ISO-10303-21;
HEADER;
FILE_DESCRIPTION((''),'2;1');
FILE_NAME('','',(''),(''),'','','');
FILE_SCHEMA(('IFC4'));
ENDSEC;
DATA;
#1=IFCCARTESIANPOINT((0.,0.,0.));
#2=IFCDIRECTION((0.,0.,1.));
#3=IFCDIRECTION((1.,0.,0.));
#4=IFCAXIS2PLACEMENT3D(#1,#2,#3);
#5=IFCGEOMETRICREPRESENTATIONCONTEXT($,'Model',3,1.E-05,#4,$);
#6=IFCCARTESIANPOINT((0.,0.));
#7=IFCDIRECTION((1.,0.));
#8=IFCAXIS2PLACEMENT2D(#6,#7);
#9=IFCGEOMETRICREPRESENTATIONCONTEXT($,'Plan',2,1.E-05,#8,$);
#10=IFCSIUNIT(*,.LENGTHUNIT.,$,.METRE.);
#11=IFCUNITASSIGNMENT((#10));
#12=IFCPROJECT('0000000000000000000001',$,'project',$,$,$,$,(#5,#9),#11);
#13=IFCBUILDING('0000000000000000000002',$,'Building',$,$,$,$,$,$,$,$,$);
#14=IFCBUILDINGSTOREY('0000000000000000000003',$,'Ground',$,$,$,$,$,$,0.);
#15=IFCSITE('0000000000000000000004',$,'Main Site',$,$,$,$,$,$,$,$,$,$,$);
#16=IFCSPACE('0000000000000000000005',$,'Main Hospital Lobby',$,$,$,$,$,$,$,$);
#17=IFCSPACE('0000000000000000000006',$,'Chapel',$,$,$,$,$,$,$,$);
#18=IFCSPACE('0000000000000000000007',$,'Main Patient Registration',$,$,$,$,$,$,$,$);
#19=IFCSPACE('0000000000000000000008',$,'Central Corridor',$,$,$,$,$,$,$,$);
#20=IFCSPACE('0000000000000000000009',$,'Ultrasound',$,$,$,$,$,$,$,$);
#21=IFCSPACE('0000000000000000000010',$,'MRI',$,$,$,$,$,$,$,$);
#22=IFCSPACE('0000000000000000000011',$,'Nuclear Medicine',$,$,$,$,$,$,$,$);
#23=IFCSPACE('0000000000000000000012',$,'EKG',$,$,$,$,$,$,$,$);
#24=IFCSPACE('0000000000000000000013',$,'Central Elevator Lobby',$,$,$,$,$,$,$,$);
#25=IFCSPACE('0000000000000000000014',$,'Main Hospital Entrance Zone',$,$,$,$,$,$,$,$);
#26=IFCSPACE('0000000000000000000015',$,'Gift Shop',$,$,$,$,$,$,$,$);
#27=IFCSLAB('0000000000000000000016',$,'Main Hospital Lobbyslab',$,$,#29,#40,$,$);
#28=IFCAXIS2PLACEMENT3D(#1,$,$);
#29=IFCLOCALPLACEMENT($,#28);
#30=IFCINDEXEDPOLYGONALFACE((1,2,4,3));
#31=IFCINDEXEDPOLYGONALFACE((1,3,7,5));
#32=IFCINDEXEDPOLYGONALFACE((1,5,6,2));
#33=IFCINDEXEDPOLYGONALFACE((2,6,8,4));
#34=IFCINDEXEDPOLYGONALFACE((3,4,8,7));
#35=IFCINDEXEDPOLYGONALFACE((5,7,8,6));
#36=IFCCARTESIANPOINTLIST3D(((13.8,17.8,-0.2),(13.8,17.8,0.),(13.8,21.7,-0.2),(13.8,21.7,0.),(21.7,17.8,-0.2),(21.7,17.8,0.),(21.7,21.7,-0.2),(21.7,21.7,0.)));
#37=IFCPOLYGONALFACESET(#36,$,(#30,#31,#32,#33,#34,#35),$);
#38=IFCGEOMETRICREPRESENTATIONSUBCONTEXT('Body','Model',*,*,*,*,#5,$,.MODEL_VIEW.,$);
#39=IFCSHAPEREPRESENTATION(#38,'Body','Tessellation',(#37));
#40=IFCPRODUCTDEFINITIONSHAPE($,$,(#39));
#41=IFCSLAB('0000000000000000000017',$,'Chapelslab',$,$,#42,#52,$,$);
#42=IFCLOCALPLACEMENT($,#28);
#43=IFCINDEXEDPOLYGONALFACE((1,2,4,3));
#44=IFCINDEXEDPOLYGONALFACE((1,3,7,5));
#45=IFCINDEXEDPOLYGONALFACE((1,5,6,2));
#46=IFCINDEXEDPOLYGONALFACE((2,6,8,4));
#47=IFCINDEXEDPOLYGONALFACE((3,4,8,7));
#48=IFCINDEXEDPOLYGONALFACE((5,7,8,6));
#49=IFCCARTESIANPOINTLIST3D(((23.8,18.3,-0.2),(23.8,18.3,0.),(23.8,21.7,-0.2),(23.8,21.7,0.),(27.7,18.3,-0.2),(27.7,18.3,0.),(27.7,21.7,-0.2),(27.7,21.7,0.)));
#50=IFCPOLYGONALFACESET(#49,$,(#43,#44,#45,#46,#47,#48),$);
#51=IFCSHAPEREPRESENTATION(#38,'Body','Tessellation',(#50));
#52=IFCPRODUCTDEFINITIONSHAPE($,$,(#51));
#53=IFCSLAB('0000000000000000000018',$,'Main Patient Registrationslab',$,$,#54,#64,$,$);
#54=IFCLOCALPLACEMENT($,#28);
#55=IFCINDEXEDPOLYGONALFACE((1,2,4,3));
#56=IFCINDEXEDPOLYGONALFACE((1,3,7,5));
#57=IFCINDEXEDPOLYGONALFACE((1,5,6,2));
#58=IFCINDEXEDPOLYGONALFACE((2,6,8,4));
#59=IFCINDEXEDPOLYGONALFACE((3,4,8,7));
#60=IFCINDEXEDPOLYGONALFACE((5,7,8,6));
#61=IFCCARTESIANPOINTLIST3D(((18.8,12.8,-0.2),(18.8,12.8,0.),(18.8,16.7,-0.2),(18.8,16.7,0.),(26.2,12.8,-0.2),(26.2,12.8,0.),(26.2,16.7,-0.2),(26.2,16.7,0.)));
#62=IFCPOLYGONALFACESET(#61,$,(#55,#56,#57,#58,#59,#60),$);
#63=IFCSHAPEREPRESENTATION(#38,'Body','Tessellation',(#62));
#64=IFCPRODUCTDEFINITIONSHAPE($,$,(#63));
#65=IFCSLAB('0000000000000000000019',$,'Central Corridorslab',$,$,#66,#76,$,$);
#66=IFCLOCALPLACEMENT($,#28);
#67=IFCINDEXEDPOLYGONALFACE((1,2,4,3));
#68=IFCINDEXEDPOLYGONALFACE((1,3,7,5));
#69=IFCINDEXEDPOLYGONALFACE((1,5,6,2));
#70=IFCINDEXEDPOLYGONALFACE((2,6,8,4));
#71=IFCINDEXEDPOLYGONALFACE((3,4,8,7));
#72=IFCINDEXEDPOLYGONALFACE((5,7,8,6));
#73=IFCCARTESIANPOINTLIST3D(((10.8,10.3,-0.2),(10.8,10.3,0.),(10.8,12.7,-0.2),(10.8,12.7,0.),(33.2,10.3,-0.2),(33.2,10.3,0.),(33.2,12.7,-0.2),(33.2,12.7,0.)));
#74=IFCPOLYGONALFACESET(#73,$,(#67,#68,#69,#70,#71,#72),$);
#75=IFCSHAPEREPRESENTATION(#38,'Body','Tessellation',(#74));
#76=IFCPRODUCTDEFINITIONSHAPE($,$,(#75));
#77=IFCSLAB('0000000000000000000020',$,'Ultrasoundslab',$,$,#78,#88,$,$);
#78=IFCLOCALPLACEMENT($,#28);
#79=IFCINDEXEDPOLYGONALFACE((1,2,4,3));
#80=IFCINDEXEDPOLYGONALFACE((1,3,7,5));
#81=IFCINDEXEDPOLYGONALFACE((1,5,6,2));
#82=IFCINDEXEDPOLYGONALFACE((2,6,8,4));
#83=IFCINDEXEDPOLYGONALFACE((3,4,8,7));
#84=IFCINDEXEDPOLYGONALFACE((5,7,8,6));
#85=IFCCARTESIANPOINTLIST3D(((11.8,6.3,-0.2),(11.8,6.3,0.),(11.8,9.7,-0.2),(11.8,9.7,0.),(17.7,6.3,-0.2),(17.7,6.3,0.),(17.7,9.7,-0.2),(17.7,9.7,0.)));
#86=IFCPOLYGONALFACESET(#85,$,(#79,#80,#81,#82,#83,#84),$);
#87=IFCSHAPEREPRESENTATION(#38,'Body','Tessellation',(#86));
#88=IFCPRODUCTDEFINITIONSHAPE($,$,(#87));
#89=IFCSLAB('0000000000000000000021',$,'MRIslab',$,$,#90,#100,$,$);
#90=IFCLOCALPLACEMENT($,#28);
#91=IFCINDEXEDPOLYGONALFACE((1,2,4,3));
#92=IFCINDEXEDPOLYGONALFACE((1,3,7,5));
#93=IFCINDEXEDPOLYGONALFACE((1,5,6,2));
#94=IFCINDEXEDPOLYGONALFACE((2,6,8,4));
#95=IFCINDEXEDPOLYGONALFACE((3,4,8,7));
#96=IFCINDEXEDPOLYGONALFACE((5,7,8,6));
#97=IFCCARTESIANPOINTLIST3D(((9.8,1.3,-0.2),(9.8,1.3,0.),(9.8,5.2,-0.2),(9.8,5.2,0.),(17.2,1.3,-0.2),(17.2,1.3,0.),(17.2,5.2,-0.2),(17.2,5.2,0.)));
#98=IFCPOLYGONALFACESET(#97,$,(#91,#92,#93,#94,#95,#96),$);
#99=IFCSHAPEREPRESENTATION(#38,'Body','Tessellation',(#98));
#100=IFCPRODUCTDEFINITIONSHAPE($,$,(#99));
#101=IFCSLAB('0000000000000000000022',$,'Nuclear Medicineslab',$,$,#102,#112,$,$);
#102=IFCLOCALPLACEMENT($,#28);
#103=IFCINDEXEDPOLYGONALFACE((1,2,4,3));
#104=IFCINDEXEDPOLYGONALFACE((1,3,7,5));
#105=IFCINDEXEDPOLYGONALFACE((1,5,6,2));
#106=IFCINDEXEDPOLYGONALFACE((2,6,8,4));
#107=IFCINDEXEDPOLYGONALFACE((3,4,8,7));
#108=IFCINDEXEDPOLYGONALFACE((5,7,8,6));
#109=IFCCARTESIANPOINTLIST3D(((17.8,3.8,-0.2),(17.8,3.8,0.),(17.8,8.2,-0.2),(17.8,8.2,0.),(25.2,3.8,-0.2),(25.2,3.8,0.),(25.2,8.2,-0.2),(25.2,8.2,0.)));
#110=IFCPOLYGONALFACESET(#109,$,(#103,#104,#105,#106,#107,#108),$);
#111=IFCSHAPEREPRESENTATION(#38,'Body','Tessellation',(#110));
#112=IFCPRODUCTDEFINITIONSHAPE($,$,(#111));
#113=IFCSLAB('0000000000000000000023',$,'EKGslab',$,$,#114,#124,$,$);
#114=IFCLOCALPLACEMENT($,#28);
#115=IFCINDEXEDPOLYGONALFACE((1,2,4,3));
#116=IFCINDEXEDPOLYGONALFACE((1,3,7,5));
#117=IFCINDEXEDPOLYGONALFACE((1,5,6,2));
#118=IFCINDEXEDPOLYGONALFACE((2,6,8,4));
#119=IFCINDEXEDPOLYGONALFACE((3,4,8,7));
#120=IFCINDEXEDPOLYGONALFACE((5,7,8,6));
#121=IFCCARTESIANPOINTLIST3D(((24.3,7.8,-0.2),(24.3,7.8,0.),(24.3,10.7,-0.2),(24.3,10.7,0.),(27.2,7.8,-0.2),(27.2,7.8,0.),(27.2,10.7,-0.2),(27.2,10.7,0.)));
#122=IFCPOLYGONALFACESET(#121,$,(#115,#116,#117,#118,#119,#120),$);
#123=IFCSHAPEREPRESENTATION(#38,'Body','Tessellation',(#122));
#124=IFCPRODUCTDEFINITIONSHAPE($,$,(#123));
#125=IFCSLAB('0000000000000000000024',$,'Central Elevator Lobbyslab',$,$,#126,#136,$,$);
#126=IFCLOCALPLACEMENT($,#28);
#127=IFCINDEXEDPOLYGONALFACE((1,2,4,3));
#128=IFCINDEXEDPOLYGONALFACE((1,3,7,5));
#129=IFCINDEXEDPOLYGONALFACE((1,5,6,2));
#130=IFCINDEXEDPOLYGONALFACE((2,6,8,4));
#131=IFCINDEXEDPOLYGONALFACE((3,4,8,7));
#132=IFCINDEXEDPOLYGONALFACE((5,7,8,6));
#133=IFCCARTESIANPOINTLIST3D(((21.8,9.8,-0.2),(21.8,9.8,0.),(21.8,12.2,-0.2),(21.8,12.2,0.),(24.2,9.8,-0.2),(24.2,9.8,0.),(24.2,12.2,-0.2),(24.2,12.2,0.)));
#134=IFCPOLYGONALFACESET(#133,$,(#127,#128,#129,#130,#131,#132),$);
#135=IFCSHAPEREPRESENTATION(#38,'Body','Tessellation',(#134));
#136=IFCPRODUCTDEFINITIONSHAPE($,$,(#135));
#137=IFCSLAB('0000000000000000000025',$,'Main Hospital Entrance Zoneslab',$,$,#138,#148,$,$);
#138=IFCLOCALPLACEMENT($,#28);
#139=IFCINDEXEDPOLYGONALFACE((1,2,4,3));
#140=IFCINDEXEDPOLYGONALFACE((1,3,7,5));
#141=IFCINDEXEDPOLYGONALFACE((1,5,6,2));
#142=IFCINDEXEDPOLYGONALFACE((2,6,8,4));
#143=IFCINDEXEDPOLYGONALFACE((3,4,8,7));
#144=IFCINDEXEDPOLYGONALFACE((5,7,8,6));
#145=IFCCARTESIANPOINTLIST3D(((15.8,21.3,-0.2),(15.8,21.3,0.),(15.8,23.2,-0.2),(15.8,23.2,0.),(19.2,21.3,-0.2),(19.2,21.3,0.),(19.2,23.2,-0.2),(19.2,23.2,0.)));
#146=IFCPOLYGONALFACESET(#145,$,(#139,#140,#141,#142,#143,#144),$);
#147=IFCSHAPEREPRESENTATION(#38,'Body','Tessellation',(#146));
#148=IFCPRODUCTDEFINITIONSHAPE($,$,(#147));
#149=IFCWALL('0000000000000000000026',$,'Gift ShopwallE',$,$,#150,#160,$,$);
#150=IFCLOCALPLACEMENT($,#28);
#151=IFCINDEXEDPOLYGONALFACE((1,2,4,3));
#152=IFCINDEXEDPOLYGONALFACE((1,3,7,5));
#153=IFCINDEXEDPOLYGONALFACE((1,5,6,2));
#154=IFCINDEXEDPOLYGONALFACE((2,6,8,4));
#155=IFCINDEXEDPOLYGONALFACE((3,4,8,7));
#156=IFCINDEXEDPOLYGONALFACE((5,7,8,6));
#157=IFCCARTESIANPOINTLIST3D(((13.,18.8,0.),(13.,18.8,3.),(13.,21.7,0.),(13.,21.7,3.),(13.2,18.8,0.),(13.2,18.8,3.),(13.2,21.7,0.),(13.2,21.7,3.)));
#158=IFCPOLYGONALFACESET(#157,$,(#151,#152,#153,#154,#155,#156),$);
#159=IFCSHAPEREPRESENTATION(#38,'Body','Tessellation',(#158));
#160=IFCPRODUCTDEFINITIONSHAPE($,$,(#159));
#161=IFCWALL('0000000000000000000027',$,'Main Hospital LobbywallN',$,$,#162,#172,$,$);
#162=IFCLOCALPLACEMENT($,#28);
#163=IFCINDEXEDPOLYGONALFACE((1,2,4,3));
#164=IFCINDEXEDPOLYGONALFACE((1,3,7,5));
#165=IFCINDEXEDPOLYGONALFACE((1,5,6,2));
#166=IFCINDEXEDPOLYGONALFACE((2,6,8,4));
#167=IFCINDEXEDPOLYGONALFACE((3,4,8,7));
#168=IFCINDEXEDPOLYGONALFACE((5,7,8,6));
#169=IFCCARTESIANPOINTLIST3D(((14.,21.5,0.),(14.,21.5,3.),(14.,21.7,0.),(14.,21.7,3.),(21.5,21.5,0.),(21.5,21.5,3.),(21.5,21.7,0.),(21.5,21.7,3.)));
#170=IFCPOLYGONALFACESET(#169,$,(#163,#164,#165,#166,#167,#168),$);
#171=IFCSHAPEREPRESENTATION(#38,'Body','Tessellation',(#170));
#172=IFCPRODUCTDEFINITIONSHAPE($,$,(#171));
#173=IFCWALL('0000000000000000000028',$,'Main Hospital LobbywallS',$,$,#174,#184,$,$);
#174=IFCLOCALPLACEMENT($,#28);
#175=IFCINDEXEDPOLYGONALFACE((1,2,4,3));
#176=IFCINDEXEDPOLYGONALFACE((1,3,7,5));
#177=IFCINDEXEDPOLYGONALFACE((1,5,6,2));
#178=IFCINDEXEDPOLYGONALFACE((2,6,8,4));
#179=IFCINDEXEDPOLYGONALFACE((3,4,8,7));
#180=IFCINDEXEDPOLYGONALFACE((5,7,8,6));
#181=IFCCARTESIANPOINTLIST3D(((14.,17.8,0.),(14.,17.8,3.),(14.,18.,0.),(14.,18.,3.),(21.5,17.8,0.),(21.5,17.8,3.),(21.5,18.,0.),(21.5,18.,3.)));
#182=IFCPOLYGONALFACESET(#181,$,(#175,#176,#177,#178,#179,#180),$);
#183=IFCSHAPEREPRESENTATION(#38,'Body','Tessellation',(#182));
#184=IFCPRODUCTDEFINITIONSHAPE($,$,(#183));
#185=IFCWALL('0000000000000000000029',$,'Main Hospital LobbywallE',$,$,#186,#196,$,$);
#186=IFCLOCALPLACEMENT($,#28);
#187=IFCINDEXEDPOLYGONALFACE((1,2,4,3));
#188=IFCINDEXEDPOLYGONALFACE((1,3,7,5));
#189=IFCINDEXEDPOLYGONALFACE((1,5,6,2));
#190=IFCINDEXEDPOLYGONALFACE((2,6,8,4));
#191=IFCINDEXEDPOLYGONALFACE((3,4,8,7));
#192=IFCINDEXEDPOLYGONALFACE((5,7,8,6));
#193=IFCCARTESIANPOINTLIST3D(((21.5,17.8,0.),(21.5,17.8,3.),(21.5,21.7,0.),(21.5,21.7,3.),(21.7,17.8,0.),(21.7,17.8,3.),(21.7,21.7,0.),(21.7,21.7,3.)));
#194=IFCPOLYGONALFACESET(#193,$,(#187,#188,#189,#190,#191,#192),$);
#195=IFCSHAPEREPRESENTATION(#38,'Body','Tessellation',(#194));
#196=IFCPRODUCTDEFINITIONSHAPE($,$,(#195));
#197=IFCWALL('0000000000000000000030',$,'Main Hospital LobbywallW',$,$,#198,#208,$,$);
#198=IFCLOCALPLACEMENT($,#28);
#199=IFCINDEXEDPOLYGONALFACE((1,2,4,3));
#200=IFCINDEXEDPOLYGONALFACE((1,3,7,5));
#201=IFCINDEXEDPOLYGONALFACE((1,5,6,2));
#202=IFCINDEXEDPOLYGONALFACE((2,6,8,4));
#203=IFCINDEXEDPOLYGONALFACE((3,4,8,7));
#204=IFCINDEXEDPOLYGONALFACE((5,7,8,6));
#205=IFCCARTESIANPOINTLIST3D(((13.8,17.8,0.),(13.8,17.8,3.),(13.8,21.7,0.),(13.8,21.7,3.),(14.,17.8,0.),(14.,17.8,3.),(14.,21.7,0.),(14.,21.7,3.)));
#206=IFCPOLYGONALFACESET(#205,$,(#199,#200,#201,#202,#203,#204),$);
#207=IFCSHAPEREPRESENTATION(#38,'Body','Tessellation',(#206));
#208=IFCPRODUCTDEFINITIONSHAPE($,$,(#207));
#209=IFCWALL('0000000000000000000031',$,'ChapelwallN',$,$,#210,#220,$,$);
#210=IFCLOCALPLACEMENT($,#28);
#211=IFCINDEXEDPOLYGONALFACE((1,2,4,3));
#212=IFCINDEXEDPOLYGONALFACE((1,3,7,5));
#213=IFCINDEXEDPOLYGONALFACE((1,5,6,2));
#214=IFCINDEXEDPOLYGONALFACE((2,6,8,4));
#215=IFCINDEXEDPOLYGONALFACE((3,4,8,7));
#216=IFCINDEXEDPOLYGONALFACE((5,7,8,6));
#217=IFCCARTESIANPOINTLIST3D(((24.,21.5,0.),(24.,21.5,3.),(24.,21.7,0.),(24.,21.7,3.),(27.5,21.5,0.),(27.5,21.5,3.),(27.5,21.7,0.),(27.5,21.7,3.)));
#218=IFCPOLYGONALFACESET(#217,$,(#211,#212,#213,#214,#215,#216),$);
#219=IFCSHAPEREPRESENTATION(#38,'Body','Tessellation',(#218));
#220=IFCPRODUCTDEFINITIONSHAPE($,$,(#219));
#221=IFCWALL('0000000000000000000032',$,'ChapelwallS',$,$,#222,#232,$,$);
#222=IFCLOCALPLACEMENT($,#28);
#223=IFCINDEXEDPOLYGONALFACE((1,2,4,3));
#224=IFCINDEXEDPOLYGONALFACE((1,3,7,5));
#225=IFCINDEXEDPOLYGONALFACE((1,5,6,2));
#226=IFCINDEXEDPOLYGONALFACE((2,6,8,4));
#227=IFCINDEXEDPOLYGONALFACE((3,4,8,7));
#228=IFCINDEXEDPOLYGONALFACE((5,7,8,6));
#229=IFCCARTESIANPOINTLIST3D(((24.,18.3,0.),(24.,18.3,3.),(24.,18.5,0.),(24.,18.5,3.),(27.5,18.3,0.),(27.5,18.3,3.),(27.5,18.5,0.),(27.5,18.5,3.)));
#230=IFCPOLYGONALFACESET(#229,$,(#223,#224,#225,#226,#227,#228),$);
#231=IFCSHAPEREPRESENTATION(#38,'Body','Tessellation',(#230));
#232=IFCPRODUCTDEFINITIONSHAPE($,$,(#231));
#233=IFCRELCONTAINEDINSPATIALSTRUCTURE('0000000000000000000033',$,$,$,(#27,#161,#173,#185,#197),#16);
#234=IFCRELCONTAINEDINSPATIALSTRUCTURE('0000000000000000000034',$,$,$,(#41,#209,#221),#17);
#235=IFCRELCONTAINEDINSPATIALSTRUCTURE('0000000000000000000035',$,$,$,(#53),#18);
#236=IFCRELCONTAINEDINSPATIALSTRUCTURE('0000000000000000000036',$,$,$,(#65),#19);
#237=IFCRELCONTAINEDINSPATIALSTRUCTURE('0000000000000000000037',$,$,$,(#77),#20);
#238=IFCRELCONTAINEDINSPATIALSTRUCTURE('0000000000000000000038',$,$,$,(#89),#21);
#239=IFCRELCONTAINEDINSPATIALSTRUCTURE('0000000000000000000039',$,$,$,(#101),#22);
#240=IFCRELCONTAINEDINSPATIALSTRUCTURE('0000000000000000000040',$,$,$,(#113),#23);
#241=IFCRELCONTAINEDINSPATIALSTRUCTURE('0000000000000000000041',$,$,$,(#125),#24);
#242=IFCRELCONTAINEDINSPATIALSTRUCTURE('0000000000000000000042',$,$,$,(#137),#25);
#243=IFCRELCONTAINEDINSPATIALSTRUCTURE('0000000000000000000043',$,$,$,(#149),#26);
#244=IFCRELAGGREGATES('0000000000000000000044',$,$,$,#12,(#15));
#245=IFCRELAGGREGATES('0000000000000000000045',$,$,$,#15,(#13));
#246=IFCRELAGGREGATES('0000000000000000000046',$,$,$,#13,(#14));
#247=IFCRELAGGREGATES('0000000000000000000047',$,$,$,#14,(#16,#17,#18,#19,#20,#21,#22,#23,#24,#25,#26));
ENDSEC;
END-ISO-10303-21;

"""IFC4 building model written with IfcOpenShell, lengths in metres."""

from ifc_helpers import new_model, si_unit, frame, origin_with_axes, origin_2d_with_axis, place, context, subcontext, project, spatial, indexed_curve, rectangle, outline, extrude, element, save


model = new_model("IFC4")

# Units and contexts
model_context = context("Model", 3, precision=1e-05, world=origin_with_axes())
plan_context = context("Plan", 2, precision=1e-05, world=origin_2d_with_axis())
body_context = subcontext(model_context, "Body", "Model", "MODEL_VIEW")
ifc_project = project(units=[si_unit("LENGTHUNIT", "METRE")], contexts=[model_context, plan_context])

# Site, building, storey, space
site = spatial("IfcSite", under=ifc_project, Name="Main Site")
building = spatial("IfcBuilding", under=site, Name="Building")
storey = spatial("IfcBuildingStorey", under=building, Name="Ground", Elevation=0.0)
space_1 = spatial("IfcSpace", under=storey, Name="Main Hospital Lobby")

# Slab
slab_1_placement = place(None, frame((17.75, 19.75, -0.2), z_axis=(0.0, 0.0, 1.0), x_axis=(1.0, 0.0, 0.0)))
element("IfcSlab", 1, at=slab_1_placement, inside=space_1, Name="Main Hospital Lobbyslab", context=body_context, shape_type="SweptSolid", body=[
    extrude(rectangle(XDim=7.9, YDim=3.9), origin_with_axes(), (0.0, 0.0, 1.0), 0.2),
])

# Shared definitions
space_2 = spatial("IfcSpace", under=storey, Name="Chapel")

# Slab
slab_2_placement = place(None, frame((25.75, 20.0, -0.2), z_axis=(0.0, 0.0, 1.0), x_axis=(1.0, 0.0, 0.0)))
element("IfcSlab", 2, at=slab_2_placement, inside=space_2, Name="Chapelslab", context=body_context, shape_type="SweptSolid", body=[
    extrude(rectangle(XDim=3.9, YDim=3.4), origin_with_axes(), (0.0, 0.0, 1.0), 0.2),
])

# Shared definitions
space_3 = spatial("IfcSpace", under=storey, Name="Main Patient Registration")

# Slab
slab_3_placement = place(None, frame((22.5, 14.75, -0.2), z_axis=(0.0, 0.0, 1.0), x_axis=(1.0, 0.0, 0.0)))
element("IfcSlab", 3, at=slab_3_placement, inside=space_3, Name="Main Patient Registrationslab", context=body_context, shape_type="SweptSolid", body=[
    extrude(rectangle(XDim=7.4, YDim=3.9), origin_with_axes(), (0.0, 0.0, 1.0), 0.2),
])

# Shared definitions
space_4 = spatial("IfcSpace", under=storey, Name="Central Corridor")

# Slab
slab_4_placement = place(None, frame((22.0, 11.5, -0.2), z_axis=(0.0, 0.0, 1.0), x_axis=(1.0, 0.0, 0.0)))
element("IfcSlab", 4, at=slab_4_placement, inside=space_4, Name="Central Corridorslab", context=body_context, shape_type="SweptSolid", body=[
    extrude(rectangle(XDim=22.4, YDim=2.4), origin_with_axes(), (0.0, 0.0, 1.0), 0.2),
])

# Shared definitions
space_5 = spatial("IfcSpace", under=storey, Name="Ultrasound")

# Slab
slab_5_placement = place(None, frame((14.75, 8.0, -0.2), z_axis=(0.0, 0.0, 1.0), x_axis=(1.0, 0.0, 0.0)))
element("IfcSlab", 5, at=slab_5_placement, inside=space_5, Name="Ultrasoundslab", context=body_context, shape_type="SweptSolid", body=[
    extrude(rectangle(XDim=5.9, YDim=3.4), origin_with_axes(), (0.0, 0.0, 1.0), 0.2),
])

# Shared definitions
space_6 = spatial("IfcSpace", under=storey, Name="MRI")

# Slab
slab_6_placement = place(None, frame((13.5, 3.25, -0.2), z_axis=(0.0, 0.0, 1.0), x_axis=(1.0, 0.0, 0.0)))
element("IfcSlab", 6, at=slab_6_placement, inside=space_6, Name="MRIslab", context=body_context, shape_type="SweptSolid", body=[
    extrude(rectangle(XDim=7.4, YDim=3.9), origin_with_axes(), (0.0, 0.0, 1.0), 0.2),
])

# Shared definitions
space_7 = spatial("IfcSpace", under=storey, Name="Nuclear Medicine")

# Slab
slab_7_placement = place(None, frame((21.5, 6.0, -0.2), z_axis=(0.0, 0.0, 1.0), x_axis=(1.0, 0.0, 0.0)))
element("IfcSlab", 7, at=slab_7_placement, inside=space_7, Name="Nuclear Medicineslab", context=body_context, shape_type="SweptSolid", body=[
    extrude(rectangle(XDim=7.4, YDim=4.4), origin_with_axes(), (0.0, 0.0, 1.0), 0.2),
])

# Shared definitions
space_8 = spatial("IfcSpace", under=storey, Name="EKG")

# Slab
slab_8_placement = place(None, frame((25.75, 9.25, -0.2), z_axis=(0.0, 0.0, 1.0), x_axis=(1.0, 0.0, 0.0)))
element("IfcSlab", 8, at=slab_8_placement, inside=space_8, Name="EKGslab", context=body_context, shape_type="SweptSolid", body=[
    extrude(rectangle(XDim=2.9, YDim=2.9), origin_with_axes(), (0.0, 0.0, 1.0), 0.2),
])

# Shared definitions
space_9 = spatial("IfcSpace", under=storey, Name="Central Elevator Lobby")

# Slab
slab_9_placement = place(None, frame((23.0, 11.0, -0.2), z_axis=(0.0, 0.0, 1.0), x_axis=(1.0, 0.0, 0.0)))
element("IfcSlab", 9, at=slab_9_placement, inside=space_9, Name="Central Elevator Lobbyslab", context=body_context, shape_type="SweptSolid", body=[
    extrude(rectangle(XDim=2.4, YDim=2.4), origin_with_axes(), (0.0, 0.0, 1.0), 0.2),
])

# Shared definitions
space_10 = spatial("IfcSpace", under=storey, Name="Main Hospital Entrance Zone")

# Slab
slab_10_placement = place(None, frame((17.5, 22.25, -0.2), z_axis=(0.0, 0.0, 1.0), x_axis=(1.0, 0.0, 0.0)))
element("IfcSlab", 10, at=slab_10_placement, inside=space_10, Name="Main Hospital Entrance Zoneslab", context=body_context, shape_type="SweptSolid", body=[
    extrude(rectangle(XDim=3.4, YDim=1.9), origin_with_axes(), (0.0, 0.0, 1.0), 0.2),
])

# Shared definitions
space_11 = spatial("IfcSpace", under=storey, Name="Gift Shop")

# Walls
wall_1_placement = place(None, frame((13.2, 18.8, 0.0), z_axis=(0.0, 0.0, 1.0), x_axis=(0.0, 1.0, 0.0)))
element("IfcWall", 11, at=wall_1_placement, inside=space_11, Name="Gift ShopwallE", context=body_context, shape_type="SweptSolid", body=[
    extrude(outline(indexed_curve([(0.0, 0.0), (0.0, 0.2), (2.9, 0.2), (2.9, 0.0), (0.0, 0.0)], self_intersect=False)), origin_with_axes(), (0.0, 0.0, 1.0), 3.0),
])
for number, where, z_axis, x_axis, name in (
    (12, (14.0, 21.5, 0.0), (0.0, 0.0, 1.0), (1.0, 0.0, 0.0), "Main Hospital LobbywallN"),
    (13, (14.0, 17.8, 0.0), (0.0, 0.0, 1.0), (1.0, 0.0, 0.0), "Main Hospital LobbywallS"),
):
    element("IfcWall", number, at=place(None, frame(where, z_axis=z_axis, x_axis=x_axis)), inside=space_1, Name=name, context=body_context, shape_type="SweptSolid", body=[
        extrude(outline(indexed_curve([(0.0, 0.0), (0.0, 0.2), (7.5, 0.2), (7.5, 0.0), (0.0, 0.0)], self_intersect=False)), origin_with_axes(), (0.0, 0.0, 1.0), 3.0),
    ])
for number, where, z_axis, x_axis, name in (
    (14, (21.7, 17.8, 0.0), (0.0, 0.0, 1.0), (0.0, 1.0, 0.0), "Main Hospital LobbywallE"),
    (15, (14.0, 17.8, 0.0), (0.0, 0.0, 1.0), (0.0, 1.0, 0.0), "Main Hospital LobbywallW"),
):
    element("IfcWall", number, at=place(None, frame(where, z_axis=z_axis, x_axis=x_axis)), inside=space_1, Name=name, context=body_context, shape_type="SweptSolid", body=[
        extrude(outline(indexed_curve([(0.0, 0.0), (0.0, 0.2), (3.9, 0.2), (3.9, 0.0), (0.0, 0.0)], self_intersect=False)), origin_with_axes(), (0.0, 0.0, 1.0), 3.0),
    ])
for number, where, z_axis, x_axis, name in (
    (16, (24.0, 21.5, 0.0), (0.0, 0.0, 1.0), (1.0, 0.0, 0.0), "ChapelwallN"),
    (17, (24.0, 18.3, 0.0), (0.0, 0.0, 1.0), (1.0, 0.0, 0.0), "ChapelwallS"),
):
    element("IfcWall", number, at=place(None, frame(where, z_axis=z_axis, x_axis=x_axis)), inside=space_2, Name=name, context=body_context, shape_type="SweptSolid", body=[
        extrude(outline(indexed_curve([(0.0, 0.0), (0.0, 0.2), (3.5, 0.2), (3.5, 0.0), (0.0, 0.0)], self_intersect=False)), origin_with_axes(), (0.0, 0.0, 1.0), 3.0),
    ])

save(model, "model.ifc")
